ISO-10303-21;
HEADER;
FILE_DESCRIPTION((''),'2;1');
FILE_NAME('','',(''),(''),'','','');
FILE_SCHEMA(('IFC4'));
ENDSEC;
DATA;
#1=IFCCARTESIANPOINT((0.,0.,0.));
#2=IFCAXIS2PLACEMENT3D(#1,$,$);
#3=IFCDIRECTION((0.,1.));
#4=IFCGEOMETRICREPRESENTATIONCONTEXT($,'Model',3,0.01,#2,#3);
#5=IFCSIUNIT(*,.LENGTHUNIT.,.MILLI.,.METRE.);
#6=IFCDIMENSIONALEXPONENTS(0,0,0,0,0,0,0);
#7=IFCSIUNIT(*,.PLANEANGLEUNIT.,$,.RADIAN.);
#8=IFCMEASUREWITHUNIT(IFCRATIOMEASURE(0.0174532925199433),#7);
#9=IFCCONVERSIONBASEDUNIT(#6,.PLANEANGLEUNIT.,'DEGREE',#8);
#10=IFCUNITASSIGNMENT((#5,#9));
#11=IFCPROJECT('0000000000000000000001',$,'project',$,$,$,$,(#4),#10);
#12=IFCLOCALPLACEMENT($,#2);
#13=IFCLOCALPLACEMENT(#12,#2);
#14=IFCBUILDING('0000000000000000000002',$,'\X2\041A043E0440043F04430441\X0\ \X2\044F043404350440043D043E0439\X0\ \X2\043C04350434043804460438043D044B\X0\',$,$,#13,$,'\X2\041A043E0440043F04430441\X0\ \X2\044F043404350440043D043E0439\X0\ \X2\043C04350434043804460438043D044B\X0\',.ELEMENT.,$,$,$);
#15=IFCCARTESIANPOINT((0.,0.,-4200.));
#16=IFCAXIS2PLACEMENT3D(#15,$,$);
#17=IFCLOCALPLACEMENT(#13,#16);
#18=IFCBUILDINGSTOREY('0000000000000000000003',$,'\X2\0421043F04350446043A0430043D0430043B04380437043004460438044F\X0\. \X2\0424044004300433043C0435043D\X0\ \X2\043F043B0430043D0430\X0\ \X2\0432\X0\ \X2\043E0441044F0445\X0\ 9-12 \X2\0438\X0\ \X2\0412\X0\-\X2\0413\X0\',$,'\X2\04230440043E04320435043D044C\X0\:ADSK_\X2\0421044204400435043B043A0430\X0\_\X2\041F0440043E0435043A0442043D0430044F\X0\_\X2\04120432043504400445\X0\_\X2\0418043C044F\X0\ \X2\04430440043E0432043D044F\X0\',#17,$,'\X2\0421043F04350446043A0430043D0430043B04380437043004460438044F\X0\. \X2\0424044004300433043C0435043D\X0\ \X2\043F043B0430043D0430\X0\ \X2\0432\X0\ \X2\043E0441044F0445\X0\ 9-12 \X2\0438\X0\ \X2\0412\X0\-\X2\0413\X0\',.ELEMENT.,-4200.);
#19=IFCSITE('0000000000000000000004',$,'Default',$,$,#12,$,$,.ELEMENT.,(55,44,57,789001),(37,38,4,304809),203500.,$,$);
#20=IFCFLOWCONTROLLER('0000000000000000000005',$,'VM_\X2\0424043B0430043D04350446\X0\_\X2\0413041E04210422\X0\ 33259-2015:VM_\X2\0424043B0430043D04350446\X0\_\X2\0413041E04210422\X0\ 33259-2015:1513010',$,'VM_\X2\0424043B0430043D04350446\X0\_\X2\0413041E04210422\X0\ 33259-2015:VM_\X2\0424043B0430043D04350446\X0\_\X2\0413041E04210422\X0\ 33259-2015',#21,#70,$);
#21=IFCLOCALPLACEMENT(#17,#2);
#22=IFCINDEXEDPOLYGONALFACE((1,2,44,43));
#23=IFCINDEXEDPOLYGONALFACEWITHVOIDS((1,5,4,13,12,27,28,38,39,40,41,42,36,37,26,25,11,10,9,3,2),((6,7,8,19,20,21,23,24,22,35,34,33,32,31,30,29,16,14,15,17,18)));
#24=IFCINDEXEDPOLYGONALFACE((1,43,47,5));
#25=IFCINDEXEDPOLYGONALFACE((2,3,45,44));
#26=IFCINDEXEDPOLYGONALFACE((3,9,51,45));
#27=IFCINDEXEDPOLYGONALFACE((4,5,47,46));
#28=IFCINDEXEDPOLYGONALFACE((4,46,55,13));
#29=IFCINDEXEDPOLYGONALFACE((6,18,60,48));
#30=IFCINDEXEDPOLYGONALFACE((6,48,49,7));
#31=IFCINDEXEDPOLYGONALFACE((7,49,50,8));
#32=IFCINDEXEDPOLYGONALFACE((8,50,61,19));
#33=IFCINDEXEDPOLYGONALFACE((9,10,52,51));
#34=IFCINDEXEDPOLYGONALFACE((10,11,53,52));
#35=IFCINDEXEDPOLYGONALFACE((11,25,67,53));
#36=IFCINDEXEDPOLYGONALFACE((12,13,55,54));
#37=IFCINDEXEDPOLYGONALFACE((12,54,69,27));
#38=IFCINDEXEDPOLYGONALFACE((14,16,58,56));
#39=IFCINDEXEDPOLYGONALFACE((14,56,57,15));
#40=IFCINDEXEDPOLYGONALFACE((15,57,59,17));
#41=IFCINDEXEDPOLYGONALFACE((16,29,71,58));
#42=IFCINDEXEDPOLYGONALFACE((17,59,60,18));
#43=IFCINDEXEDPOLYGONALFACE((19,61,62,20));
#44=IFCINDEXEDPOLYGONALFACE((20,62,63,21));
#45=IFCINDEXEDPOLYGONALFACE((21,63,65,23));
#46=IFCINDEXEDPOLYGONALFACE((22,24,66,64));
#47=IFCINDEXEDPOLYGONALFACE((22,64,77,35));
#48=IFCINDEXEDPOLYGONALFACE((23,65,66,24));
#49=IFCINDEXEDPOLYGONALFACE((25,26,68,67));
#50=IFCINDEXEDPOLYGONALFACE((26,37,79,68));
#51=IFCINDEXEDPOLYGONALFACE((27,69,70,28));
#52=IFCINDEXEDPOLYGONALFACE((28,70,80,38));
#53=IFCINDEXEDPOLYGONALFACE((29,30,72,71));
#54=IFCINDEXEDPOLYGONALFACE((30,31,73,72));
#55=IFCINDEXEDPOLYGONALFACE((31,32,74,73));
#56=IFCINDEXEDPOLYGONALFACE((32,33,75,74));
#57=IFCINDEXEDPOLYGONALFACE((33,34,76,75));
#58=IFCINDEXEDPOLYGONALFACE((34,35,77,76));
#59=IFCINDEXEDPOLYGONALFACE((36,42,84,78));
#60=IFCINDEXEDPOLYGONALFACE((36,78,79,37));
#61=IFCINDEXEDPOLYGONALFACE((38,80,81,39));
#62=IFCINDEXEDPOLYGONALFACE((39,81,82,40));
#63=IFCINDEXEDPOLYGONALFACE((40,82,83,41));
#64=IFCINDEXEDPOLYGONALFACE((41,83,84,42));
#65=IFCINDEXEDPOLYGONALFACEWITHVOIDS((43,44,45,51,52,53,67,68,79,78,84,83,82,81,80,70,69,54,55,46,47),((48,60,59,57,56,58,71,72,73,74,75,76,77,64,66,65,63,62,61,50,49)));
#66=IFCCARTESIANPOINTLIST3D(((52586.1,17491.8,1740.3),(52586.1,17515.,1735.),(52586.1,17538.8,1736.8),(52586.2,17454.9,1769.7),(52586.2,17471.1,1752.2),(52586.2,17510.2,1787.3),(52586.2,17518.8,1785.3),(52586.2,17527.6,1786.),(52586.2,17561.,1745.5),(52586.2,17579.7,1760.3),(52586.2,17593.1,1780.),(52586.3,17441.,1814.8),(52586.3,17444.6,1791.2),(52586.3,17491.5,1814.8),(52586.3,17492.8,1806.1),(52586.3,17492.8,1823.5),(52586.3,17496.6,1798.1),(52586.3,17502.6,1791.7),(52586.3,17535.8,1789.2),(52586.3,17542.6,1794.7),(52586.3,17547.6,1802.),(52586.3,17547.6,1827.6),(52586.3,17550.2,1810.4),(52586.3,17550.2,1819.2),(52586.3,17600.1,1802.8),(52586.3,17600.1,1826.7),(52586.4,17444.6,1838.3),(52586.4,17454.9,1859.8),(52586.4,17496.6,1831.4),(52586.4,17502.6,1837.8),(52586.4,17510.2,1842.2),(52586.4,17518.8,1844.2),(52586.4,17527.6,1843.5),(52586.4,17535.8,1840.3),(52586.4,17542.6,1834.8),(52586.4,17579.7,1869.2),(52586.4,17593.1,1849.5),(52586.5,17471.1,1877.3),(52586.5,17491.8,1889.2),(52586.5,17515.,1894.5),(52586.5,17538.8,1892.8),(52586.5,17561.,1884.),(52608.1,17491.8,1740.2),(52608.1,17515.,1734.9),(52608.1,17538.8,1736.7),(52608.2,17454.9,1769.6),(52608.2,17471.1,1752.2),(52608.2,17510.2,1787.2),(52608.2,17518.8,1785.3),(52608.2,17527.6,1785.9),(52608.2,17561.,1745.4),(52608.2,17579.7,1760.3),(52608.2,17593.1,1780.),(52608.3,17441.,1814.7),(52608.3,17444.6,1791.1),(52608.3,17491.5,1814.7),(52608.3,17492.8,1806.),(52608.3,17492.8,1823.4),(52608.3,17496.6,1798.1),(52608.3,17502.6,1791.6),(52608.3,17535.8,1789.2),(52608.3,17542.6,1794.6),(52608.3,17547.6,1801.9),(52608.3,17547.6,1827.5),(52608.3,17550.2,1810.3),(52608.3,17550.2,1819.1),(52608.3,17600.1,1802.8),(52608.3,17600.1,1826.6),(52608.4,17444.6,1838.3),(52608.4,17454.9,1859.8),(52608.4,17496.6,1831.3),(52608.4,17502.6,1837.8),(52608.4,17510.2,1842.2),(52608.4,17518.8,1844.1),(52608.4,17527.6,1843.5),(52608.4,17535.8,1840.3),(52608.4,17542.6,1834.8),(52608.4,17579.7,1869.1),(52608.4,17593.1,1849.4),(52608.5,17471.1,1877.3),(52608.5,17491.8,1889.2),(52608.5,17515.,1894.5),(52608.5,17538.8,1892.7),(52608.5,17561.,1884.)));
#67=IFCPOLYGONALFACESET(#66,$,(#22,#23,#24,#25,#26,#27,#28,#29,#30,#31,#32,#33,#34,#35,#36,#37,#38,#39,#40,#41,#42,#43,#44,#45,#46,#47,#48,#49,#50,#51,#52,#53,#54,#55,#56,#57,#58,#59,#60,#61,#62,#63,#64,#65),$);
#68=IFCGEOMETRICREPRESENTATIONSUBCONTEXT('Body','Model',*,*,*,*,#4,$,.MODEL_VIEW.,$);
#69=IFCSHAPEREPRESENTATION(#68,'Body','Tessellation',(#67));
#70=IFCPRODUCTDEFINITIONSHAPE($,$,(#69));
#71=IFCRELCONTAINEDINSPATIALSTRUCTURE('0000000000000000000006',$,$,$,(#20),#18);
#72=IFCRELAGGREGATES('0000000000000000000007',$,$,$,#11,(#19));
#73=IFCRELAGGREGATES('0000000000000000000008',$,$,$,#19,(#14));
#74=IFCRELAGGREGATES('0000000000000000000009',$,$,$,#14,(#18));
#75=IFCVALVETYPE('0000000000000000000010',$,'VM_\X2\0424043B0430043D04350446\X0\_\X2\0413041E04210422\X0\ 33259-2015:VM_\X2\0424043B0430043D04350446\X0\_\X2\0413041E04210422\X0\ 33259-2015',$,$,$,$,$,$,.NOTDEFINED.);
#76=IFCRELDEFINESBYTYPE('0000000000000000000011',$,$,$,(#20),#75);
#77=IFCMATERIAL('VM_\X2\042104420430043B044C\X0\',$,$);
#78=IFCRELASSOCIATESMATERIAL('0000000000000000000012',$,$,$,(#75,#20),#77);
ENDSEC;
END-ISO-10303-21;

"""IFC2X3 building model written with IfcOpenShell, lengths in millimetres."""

from ifc_helpers import new_model, entity, si_unit, converted_unit, direction, frame, frame_2d, origin, place, context, subcontext, project, spatial, hollow_circle, extrude, source, transform, mapped, material, type_object, type_shapes, element, save


model = new_model("IFC2X3")

# Units and contexts
model_context = context("Model", 3, precision=0.01, world=origin(), true_north=direction((0.0, 1.0)))
body_context = subcontext(model_context, "Body", "Model", "MODEL_VIEW")
ifc_project = project(units=[si_unit("LENGTHUNIT", "METRE", prefix="MILLI"), converted_unit("PLANEANGLEUNIT", "DEGREE", entity("IfcRatioMeasure", 0.0174532925199433), si_unit("PLANEANGLEUNIT", "RADIAN"), dimensions=[0, 0, 0, 0, 0, 0, 0])], contexts=[model_context])

# Site, building, storey
site_placement = place(None, frame((0.0, 0.0, 0.0)))
site = spatial("IfcSite", under=ifc_project, at=site_placement, Name="Default", CompositionType="ELEMENT", RefLatitude=(55, 44, 57, 789001), RefLongitude=(37, 38, 4, 304809), RefElevation=203500.0)
building_placement = place(site_placement, origin())
building = spatial("IfcBuilding", under=site, at=building_placement, Name="Корпус ядерной медицины", LongName="Корпус ядерной медицины", CompositionType="ELEMENT")
storey_placement = place(building_placement, frame((0.0, 0.0, -4200.0)))
storey = spatial("IfcBuildingStorey", under=building, at=storey_placement, Name="Спецканализация. Фрагмен плана в осях 9-12 и В-Г", ObjectType="Уровень:ADSK_Стрелка_Проектная_Вверх_Имя уровня", LongName="Спецканализация. Фрагмен плана в осях 9-12 и В-Г", CompositionType="ELEMENT", Elevation=-4200.0)

# Flow controller
ifc_material_1 = material(Name="VM_Сталь")
valve_type_1 = type_object("IfcValveType", Name="VM_Фланец_ГОСТ 33259-2015:VM_Фланец_ГОСТ 33259-2015", PredefinedType="NOTDEFINED", material=ifc_material_1)
shared_shape_1 = source(origin(), body_context, "Body", "SweptSolid", [
    extrude(hollow_circle(Radius=80.0, WallThickness=50.5, at=frame_2d((0.0, 0.0), x_axis=(1.0, 0.0))), frame((0.0, 0.0, 0.0), z_axis=(1.0, 0.0, 0.0), x_axis=(0.0, 1.0, 0.0)), (0.0, 0.0, 1.0), 22.0),
])
type_shapes(valve_type_1, [shared_shape_1])
for number, where, z_axis, x_axis, name in (
    (1, (52608.3, 17521.0, 1814.7), (0.002338, 0.0, 0.999997), (-0.999997, -0.000027, 0.002338), "VM_Фланец_ГОСТ 33259-2015:VM_Фланец_ГОСТ 33259-2015:1513010"),
):
    element("IfcFlowController", number, at=place(storey_placement, frame(where, z_axis=z_axis, x_axis=x_axis)), inside=storey, type_object=valve_type_1, material=ifc_material_1, Name=name, ObjectType="VM_Фланец_ГОСТ 33259-2015:VM_Фланец_ГОСТ 33259-2015", context=body_context, shape_type="MappedRepresentation", body=[
        mapped(shared_shape_1, transform((0.0, 0.0, 0.0), scale=1.0)),
    ])

save(model, "model.ifc")
